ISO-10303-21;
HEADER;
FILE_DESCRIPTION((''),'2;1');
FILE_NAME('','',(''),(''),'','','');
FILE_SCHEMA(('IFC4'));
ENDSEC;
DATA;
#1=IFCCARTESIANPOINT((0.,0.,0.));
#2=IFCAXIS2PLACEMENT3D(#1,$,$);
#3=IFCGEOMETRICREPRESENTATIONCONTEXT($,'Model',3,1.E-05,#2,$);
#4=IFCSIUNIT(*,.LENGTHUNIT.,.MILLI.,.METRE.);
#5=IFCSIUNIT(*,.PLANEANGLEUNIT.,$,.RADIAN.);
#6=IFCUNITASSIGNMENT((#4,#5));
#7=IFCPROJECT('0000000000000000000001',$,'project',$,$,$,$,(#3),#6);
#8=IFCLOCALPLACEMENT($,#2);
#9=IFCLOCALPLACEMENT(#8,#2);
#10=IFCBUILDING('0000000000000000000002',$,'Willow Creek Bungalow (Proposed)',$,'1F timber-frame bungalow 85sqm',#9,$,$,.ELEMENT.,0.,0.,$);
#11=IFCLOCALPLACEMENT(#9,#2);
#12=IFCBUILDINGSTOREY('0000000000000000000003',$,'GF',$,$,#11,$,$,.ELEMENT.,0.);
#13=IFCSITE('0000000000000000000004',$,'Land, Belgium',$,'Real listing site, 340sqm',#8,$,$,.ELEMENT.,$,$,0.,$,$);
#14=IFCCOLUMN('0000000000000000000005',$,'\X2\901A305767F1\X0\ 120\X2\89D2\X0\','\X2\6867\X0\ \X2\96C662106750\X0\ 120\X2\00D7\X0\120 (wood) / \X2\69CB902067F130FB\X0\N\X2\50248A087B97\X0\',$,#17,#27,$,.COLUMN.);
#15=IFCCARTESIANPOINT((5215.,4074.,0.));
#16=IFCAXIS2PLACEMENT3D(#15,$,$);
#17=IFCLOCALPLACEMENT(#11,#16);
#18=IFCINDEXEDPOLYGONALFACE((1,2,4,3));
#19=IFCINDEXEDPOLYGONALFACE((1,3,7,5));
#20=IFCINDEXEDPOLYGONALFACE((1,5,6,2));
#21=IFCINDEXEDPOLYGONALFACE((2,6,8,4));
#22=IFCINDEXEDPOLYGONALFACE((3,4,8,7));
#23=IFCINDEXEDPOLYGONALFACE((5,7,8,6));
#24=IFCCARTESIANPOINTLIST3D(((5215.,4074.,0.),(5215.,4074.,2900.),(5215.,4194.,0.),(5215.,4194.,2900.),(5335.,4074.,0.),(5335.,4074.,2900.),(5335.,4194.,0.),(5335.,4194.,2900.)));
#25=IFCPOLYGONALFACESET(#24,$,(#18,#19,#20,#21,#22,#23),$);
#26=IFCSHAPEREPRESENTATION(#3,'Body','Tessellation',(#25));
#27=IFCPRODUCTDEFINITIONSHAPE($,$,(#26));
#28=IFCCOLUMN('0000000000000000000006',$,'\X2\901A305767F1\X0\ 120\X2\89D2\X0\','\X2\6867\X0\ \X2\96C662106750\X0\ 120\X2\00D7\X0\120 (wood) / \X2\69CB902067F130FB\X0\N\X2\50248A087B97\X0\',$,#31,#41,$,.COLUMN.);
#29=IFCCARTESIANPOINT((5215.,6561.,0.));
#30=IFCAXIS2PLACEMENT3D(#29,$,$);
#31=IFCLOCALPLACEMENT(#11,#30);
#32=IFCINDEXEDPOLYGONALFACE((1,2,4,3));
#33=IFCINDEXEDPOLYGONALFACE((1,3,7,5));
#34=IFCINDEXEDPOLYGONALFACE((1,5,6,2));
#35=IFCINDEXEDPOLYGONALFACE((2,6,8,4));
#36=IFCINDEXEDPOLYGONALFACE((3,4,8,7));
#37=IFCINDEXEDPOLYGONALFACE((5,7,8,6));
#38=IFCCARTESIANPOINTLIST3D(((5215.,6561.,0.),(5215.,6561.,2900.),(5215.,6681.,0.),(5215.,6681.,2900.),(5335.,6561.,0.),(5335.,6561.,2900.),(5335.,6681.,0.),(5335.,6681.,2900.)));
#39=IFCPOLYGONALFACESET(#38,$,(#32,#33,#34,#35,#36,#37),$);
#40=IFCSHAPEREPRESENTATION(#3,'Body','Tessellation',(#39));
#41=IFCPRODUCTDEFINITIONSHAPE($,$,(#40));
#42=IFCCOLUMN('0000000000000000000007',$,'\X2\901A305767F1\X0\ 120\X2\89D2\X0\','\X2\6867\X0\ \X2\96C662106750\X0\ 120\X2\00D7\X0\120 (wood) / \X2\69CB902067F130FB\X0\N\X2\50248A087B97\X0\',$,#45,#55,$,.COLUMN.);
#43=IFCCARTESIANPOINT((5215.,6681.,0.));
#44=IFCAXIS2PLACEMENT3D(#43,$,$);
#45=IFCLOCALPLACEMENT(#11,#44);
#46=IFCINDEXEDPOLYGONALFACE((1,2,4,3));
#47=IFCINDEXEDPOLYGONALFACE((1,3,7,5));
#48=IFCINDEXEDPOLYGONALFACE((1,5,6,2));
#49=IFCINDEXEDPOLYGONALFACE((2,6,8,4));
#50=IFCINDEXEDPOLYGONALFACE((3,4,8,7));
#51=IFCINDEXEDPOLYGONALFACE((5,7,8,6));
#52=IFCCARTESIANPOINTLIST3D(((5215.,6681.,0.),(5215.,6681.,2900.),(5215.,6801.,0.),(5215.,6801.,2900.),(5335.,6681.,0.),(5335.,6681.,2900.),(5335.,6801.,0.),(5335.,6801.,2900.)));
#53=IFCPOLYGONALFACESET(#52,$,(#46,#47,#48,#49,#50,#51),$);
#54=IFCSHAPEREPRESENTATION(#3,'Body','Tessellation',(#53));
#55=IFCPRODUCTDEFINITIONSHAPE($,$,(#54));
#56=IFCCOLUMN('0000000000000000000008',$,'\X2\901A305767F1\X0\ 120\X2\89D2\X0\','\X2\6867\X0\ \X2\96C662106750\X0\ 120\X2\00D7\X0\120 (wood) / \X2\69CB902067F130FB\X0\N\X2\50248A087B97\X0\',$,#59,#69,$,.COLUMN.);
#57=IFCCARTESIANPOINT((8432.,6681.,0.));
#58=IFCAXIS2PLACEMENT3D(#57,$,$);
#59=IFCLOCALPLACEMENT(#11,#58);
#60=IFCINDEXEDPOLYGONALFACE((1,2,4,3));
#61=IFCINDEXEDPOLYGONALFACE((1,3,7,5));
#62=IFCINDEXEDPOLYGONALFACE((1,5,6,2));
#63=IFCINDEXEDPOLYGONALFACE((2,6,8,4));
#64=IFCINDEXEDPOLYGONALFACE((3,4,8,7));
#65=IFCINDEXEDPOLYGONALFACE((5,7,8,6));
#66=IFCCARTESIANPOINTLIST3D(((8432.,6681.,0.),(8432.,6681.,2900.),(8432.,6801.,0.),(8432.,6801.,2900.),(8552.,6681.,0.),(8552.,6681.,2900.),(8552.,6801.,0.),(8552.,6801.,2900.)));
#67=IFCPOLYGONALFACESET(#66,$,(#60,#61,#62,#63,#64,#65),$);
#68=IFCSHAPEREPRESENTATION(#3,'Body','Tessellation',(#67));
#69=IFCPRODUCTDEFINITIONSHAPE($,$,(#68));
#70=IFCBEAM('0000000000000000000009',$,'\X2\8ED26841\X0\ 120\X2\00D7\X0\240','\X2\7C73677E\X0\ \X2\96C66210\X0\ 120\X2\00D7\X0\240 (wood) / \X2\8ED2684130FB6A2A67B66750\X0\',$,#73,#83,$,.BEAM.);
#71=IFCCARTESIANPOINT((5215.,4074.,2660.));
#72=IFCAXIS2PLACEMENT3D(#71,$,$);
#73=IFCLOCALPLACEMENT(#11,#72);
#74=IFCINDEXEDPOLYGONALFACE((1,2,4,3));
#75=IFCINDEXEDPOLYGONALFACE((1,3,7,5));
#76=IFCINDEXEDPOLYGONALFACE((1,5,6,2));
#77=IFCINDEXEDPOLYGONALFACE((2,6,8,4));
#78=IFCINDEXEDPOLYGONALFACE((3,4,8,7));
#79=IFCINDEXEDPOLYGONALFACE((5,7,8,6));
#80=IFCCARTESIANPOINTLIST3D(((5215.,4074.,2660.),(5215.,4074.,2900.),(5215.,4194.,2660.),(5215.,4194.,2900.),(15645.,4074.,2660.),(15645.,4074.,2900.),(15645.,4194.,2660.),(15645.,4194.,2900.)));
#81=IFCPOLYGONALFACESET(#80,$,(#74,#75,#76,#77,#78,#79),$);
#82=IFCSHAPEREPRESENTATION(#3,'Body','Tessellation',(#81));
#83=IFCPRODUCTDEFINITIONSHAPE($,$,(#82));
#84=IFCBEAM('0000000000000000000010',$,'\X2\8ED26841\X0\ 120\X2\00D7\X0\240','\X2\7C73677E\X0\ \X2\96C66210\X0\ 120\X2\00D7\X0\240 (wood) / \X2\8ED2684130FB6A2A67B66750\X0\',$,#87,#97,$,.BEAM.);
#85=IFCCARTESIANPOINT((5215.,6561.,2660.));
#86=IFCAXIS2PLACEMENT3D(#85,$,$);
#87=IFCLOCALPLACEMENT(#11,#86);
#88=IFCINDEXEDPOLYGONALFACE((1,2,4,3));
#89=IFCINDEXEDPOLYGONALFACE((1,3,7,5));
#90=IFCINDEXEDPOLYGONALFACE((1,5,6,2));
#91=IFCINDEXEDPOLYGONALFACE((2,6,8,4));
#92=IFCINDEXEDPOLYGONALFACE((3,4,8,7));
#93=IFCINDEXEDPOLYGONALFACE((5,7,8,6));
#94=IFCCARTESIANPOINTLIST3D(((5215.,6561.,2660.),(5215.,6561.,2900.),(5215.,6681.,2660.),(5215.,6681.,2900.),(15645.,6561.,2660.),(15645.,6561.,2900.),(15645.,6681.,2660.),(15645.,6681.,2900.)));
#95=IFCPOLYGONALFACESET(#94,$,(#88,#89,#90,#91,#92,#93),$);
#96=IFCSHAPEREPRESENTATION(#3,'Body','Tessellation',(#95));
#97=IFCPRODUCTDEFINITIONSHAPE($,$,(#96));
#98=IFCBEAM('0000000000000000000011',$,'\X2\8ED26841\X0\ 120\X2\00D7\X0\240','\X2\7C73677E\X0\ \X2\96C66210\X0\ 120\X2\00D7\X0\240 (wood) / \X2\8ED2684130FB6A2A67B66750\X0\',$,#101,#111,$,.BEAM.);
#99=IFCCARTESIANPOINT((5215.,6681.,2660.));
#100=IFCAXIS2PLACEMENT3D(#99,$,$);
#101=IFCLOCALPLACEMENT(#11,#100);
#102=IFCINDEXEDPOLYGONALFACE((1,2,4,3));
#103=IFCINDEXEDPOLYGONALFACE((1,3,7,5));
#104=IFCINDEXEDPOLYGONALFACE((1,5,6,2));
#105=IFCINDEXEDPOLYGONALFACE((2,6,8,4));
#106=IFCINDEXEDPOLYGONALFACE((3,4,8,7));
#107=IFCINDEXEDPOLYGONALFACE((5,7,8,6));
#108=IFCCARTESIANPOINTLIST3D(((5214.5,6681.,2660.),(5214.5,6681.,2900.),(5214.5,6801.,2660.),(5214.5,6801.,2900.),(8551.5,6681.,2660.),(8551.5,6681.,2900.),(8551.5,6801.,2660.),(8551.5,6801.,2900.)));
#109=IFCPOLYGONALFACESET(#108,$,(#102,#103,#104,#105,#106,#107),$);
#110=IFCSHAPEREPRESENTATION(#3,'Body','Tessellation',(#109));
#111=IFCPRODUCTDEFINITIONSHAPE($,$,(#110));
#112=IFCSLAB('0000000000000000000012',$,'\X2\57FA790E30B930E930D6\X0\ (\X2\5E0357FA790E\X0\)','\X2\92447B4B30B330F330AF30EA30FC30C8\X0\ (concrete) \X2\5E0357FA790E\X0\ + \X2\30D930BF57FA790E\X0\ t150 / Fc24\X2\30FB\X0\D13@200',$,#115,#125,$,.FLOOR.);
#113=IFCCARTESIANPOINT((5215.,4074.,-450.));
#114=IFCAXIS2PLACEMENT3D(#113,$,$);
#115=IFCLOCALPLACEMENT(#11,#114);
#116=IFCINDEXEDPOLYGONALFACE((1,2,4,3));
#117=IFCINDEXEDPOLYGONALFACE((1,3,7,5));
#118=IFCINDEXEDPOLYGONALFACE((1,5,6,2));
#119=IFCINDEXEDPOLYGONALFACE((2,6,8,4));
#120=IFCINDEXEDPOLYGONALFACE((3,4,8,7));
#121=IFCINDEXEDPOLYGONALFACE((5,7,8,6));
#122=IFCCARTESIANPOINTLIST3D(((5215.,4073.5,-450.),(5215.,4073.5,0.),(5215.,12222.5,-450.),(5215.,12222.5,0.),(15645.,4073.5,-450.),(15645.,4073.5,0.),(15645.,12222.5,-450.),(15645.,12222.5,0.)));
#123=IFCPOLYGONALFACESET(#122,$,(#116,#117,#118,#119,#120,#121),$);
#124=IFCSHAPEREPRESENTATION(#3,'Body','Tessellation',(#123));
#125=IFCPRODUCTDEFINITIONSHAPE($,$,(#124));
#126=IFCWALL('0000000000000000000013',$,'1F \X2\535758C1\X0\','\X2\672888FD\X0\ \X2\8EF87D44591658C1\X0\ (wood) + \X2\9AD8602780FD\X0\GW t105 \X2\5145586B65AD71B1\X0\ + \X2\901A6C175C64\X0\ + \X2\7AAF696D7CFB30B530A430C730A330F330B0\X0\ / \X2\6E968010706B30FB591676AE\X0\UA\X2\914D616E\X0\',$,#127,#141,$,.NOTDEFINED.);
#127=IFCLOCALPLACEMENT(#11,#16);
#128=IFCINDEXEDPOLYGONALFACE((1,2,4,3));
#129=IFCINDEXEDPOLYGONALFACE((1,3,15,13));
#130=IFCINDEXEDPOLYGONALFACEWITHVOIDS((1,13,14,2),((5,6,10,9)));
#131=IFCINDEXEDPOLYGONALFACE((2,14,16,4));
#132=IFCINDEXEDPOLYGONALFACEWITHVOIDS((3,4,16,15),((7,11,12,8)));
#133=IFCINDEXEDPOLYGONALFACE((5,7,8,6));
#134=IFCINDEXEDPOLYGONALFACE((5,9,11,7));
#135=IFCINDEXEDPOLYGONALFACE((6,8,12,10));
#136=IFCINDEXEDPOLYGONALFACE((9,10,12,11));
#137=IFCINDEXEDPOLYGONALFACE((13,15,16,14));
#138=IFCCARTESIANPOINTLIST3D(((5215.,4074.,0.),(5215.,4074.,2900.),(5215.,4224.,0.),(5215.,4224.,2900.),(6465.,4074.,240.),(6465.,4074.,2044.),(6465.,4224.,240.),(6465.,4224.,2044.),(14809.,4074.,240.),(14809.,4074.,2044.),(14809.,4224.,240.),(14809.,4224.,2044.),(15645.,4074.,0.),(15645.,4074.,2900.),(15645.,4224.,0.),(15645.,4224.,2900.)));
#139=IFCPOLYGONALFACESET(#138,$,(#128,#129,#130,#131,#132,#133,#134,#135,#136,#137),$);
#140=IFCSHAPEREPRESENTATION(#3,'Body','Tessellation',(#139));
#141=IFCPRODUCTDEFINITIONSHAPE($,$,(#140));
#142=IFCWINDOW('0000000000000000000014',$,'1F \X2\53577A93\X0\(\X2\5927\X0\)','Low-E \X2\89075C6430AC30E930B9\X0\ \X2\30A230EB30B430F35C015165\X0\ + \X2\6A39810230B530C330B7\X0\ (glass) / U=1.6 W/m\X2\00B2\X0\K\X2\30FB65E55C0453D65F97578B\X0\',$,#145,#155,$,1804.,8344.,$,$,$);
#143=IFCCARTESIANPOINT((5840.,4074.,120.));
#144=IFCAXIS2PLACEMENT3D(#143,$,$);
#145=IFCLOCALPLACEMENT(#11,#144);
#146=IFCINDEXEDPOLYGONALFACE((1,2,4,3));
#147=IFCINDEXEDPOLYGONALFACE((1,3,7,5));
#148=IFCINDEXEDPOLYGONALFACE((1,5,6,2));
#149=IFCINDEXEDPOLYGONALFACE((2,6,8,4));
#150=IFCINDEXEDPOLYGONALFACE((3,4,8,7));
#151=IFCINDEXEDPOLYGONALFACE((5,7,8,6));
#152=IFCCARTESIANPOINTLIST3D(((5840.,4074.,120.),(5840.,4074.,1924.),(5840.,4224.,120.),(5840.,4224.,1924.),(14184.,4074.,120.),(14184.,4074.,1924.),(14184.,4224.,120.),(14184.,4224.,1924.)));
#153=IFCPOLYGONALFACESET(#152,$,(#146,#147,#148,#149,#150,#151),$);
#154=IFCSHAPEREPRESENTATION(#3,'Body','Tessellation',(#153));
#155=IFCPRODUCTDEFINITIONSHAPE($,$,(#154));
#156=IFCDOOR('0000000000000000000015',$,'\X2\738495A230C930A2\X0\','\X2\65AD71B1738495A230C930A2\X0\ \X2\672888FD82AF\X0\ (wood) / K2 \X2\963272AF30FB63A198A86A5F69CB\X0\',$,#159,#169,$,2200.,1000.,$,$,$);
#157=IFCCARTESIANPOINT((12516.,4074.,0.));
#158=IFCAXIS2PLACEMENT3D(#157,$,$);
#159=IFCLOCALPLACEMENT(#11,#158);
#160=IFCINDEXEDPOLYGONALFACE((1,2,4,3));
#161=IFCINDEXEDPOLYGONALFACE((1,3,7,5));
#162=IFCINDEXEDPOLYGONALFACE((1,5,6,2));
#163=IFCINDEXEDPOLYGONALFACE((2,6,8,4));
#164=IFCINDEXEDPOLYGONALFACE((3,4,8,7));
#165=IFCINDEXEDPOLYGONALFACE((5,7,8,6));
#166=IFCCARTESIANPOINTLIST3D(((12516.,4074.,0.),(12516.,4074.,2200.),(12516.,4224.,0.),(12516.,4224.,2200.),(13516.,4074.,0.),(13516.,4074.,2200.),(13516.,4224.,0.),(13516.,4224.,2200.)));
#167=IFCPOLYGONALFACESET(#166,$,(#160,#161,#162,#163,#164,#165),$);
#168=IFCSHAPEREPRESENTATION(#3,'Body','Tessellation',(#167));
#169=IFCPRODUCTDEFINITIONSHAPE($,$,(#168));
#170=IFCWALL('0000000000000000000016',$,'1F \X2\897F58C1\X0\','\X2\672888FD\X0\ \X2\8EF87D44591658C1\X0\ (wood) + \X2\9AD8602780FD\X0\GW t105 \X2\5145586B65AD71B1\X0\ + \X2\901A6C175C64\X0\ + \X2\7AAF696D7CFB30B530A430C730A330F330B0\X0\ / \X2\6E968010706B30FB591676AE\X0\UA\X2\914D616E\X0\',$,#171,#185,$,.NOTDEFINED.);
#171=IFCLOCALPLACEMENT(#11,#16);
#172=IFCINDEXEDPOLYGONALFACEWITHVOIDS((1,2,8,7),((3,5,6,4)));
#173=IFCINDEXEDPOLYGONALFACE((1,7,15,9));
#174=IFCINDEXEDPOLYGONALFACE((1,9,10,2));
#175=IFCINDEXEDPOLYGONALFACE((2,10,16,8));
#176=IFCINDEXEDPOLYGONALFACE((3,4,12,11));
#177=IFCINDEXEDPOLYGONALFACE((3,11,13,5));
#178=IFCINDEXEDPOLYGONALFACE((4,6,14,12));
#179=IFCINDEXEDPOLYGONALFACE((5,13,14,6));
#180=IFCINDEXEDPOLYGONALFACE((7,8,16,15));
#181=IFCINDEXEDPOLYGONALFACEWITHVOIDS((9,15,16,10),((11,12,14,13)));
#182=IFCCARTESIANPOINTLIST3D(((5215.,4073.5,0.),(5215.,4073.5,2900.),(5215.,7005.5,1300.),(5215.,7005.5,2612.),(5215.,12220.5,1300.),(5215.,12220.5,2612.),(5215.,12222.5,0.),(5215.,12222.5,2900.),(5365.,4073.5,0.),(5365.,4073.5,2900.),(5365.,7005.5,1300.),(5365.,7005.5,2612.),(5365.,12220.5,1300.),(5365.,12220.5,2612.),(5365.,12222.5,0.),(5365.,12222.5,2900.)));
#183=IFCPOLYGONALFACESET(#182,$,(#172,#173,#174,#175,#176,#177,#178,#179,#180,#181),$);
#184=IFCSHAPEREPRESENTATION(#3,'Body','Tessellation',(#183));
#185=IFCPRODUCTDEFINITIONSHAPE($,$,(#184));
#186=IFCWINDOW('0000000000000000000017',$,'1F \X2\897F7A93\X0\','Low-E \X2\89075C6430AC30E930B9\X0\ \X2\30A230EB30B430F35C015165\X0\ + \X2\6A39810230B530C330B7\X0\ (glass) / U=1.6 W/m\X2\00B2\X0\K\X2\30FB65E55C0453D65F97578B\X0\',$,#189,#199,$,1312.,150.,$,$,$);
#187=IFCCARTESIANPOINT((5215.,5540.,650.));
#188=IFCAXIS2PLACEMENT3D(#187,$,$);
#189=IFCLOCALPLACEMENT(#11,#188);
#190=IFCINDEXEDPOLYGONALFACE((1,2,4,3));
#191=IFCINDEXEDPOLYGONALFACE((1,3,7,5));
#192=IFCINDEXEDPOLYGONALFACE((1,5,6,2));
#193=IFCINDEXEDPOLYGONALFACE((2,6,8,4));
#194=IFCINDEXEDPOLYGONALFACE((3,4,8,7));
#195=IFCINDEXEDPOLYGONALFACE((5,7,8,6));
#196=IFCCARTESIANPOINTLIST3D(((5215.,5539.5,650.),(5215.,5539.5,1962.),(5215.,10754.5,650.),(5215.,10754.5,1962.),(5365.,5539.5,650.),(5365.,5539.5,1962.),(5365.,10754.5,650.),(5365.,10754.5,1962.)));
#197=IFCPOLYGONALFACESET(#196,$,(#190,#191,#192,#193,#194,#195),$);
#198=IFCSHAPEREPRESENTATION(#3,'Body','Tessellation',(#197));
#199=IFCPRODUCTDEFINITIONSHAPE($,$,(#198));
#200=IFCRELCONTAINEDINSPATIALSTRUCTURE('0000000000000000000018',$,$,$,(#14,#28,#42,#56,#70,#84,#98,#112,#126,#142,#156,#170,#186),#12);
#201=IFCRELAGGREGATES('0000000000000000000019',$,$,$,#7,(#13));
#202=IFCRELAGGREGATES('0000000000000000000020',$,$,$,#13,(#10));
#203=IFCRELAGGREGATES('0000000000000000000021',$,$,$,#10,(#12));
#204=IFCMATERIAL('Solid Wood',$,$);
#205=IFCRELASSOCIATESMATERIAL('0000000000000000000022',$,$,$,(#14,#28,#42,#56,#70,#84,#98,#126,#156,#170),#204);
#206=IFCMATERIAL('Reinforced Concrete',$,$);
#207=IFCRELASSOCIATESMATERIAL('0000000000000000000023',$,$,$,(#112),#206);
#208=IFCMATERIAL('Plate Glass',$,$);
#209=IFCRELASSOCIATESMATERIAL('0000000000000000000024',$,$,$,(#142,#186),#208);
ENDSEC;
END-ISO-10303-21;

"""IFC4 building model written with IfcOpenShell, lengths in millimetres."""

from ifc_helpers import new_model, si_unit, frame, frame_2d, origin, place, context, project, spatial, rectangle, extrude, material, element, fill, save


model = new_model("IFC4")

# Units and contexts
model_context = context("Model", 3, precision=1e-05, world=origin())
ifc_project = project(units=[si_unit("LENGTHUNIT", "METRE", prefix="MILLI"), si_unit("PLANEANGLEUNIT", "RADIAN")], contexts=[model_context])

# Site, building, storey
site_placement = place(None, origin())
site = spatial("IfcSite", under=ifc_project, at=site_placement, Name="Land, Belgium", ObjectType="Real listing site, 340sqm", CompositionType="ELEMENT", RefElevation=0.0)
building_placement = place(site_placement, origin())
building = spatial("IfcBuilding", under=site, at=building_placement, Name="Willow Creek Bungalow (Proposed)", ObjectType="1F timber-frame bungalow 85sqm", CompositionType="ELEMENT", ElevationOfRefHeight=0.0, ElevationOfTerrain=0.0)
storey_placement = place(building_placement, origin())
storey = spatial("IfcBuildingStorey", under=building, at=storey_placement, Name="GF", CompositionType="ELEMENT", Elevation=0.0)

# Columns
ifc_material_1 = material(Name="Solid Wood")
column_1_placement = place(storey_placement, frame((5215.0, 4074.0, 0.0)))
element("IfcColumn", 1, at=column_1_placement, inside=storey, material=ifc_material_1, Name="通し柱 120角", Description="桧 集成材 120×120 (wood) / 構造柱・N値計算", PredefinedType="COLUMN", context=model_context, shape_type="SweptSolid", body=[
    extrude(rectangle(XDim=120.0, YDim=120.0, at=frame_2d((60.0, 60.0))), frame((5215.0, 4074.0, 0.0)), (0.0, 0.0, 1.0), 2900.0),
])
column_2_placement = place(storey_placement, frame((5215.0, 6561.0, 0.0)))
element("IfcColumn", 2, at=column_2_placement, inside=storey, material=ifc_material_1, Name="通し柱 120角", Description="桧 集成材 120×120 (wood) / 構造柱・N値計算", PredefinedType="COLUMN", context=model_context, shape_type="SweptSolid", body=[
    extrude(rectangle(XDim=120.0, YDim=120.0, at=frame_2d((60.0, 60.0))), frame((5215.0, 6561.0, 0.0)), (0.0, 0.0, 1.0), 2900.0),
])
column_3_placement = place(storey_placement, frame((5215.0, 6681.0, 0.0)))
element("IfcColumn", 3, at=column_3_placement, inside=storey, material=ifc_material_1, Name="通し柱 120角", Description="桧 集成材 120×120 (wood) / 構造柱・N値計算", PredefinedType="COLUMN", context=model_context, shape_type="SweptSolid", body=[
    extrude(rectangle(XDim=120.0, YDim=120.0, at=frame_2d((60.0, 60.0))), frame((5215.0, 6681.0, 0.0)), (0.0, 0.0, 1.0), 2900.0),
])
column_4_placement = place(storey_placement, frame((8432.0, 6681.0, 0.0)))
element("IfcColumn", 4, at=column_4_placement, inside=storey, material=ifc_material_1, Name="通し柱 120角", Description="桧 集成材 120×120 (wood) / 構造柱・N値計算", PredefinedType="COLUMN", context=model_context, shape_type="SweptSolid", body=[
    extrude(rectangle(XDim=120.0, YDim=120.0, at=frame_2d((60.0, 60.0))), frame((8432.0, 6681.0, 0.0)), (0.0, 0.0, 1.0), 2900.0),
])

# Beams
beam_1_placement = place(storey_placement, frame((5215.0, 4074.0, 2660.0)))
element("IfcBeam", 5, at=beam_1_placement, inside=storey, material=ifc_material_1, Name="軒桁 120×240", Description="米松 集成 120×240 (wood) / 軒桁・横架材", PredefinedType="BEAM", context=model_context, shape_type="SweptSolid", body=[
    extrude(rectangle(XDim=10430.0, YDim=120.0, at=frame_2d((5215.0, 60.0))), frame((5215.0, 4074.0, 2660.0)), (0.0, 0.0, 1.0), 240.0),
])
beam_2_placement = place(storey_placement, frame((5215.0, 6561.0, 2660.0)))
element("IfcBeam", 6, at=beam_2_placement, inside=storey, material=ifc_material_1, Name="軒桁 120×240", Description="米松 集成 120×240 (wood) / 軒桁・横架材", PredefinedType="BEAM", context=model_context, shape_type="SweptSolid", body=[
    extrude(rectangle(XDim=10430.0, YDim=120.0, at=frame_2d((5215.0, 60.0))), frame((5215.0, 6561.0, 2660.0)), (0.0, 0.0, 1.0), 240.0),
])
beam_3_placement = place(storey_placement, frame((5215.0, 6681.0, 2660.0)))
element("IfcBeam", 7, at=beam_3_placement, inside=storey, material=ifc_material_1, Name="軒桁 120×240", Description="米松 集成 120×240 (wood) / 軒桁・横架材", PredefinedType="BEAM", context=model_context, shape_type="SweptSolid", body=[
    extrude(rectangle(XDim=3337.0, YDim=120.0, at=frame_2d((1668.0, 60.0))), frame((5215.0, 6681.0, 2660.0)), (0.0, 0.0, 1.0), 240.0),
])

# Slab
ifc_material_2 = material(Name="Reinforced Concrete")
slab_1_placement = place(storey_placement, frame((5215.0, 4074.0, -450.0)))
element("IfcSlab", 8, at=slab_1_placement, inside=storey, material=ifc_material_2, Name="基礎スラブ (布基礎)", Description="鉄筋コンクリート (concrete) 布基礎 + ベタ基礎 t150 / Fc24・D13@200", PredefinedType="FLOOR", context=model_context, shape_type="SweptSolid", body=[
    extrude(rectangle(XDim=10430.0, YDim=8149.0, at=frame_2d((5215.0, 4074.0))), frame((5215.0, 4074.0, -450.0)), (0.0, 0.0, 1.0), 450.0),
])

# Wall, openings, window, door
wall_1_placement = place(storey_placement, frame((5215.0, 4074.0, 0.0)))
wall_1 = element("IfcWall", 9, at=wall_1_placement, inside=storey, material=ifc_material_1, Name="1F 南壁", Description="木製 軸組外壁 (wood) + 高性能GW t105 充填断熱 + 通気層 + 窯業系サイディング / 準耐火・外皮UA配慮", PredefinedType="NOTDEFINED", context=model_context, shape_type="SweptSolid", body=[
    extrude(rectangle(XDim=10430.0, YDim=150.0, at=frame_2d((5215.0, 75.0))), frame((5215.0, 4074.0, 0.0)), (0.0, 0.0, 1.0), 2900.0),
])
opening_1_placement = place(storey_placement, frame((5840.0, 4074.0, 120.0)))
opening_1 = element("IfcOpeningElement", 10, at=opening_1_placement, cuts=wall_1, PredefinedType="NOTDEFINED", context=model_context, shape_type="SweptSolid", body=[
    extrude(rectangle(XDim=8344.0, YDim=150.0, at=frame_2d((4172.0, 75.0))), frame((5840.0, 4074.0, 120.0)), (0.0, 0.0, 1.0), 1804.0),
])
opening_2_placement = place(storey_placement, frame((12516.0, 4074.0, 0.0)))
opening_2 = element("IfcOpeningElement", 11, at=opening_2_placement, cuts=wall_1, PredefinedType="NOTDEFINED", context=model_context, shape_type="SweptSolid", body=[
    extrude(rectangle(XDim=1000.0, YDim=150.0, at=frame_2d((500.0, 75.0))), frame((12516.0, 4074.0, 0.0)), (0.0, 0.0, 1.0), 2200.0),
])
ifc_material_3 = material(Name="Plate Glass")
window_1_placement = place(storey_placement, frame((5840.0, 4074.0, 120.0)))
window_1 = element("IfcWindow", 12, at=window_1_placement, inside=storey, material=ifc_material_3, Name="1F 南窓(大)", Description="Low-E 複層ガラス アルゴン封入 + 樹脂サッシ (glass) / U=1.6 W/m²K・日射取得型", OverallHeight=1804.0, OverallWidth=8344.0, context=model_context, shape_type="SweptSolid", body=[
    extrude(rectangle(XDim=8344.0, YDim=150.0, at=frame_2d((4172.0, 75.0))), frame((5840.0, 4074.0, 120.0)), (0.0, 0.0, 1.0), 1804.0),
])
fill(opening_1, window_1)
door_placement = place(storey_placement, frame((12516.0, 4074.0, 0.0)))
door = element("IfcDoor", 13, at=door_placement, inside=storey, material=ifc_material_1, Name="玄関ドア", Description="断熱玄関ドア 木製芯 (wood) / K2 防犯・採風機構", OverallHeight=2200.0, OverallWidth=1000.0, context=model_context, shape_type="SweptSolid", body=[
    extrude(rectangle(XDim=1000.0, YDim=150.0, at=frame_2d((500.0, 75.0))), frame((12516.0, 4074.0, 0.0)), (0.0, 0.0, 1.0), 2200.0),
])
fill(opening_2, door)

# Wall, opening, window
wall_2_placement = place(storey_placement, frame((5215.0, 4074.0, 0.0)))
wall_2 = element("IfcWall", 14, at=wall_2_placement, inside=storey, material=ifc_material_1, Name="1F 西壁", Description="木製 軸組外壁 (wood) + 高性能GW t105 充填断熱 + 通気層 + 窯業系サイディング / 準耐火・外皮UA配慮", PredefinedType="NOTDEFINED", context=model_context, shape_type="SweptSolid", body=[
    extrude(rectangle(XDim=150.0, YDim=8149.0, at=frame_2d((75.0, 4074.0))), frame((5215.0, 4074.0, 0.0)), (0.0, 0.0, 1.0), 2900.0),
])
opening_3_placement = place(storey_placement, frame((5215.0, 5540.0, 650.0)))
opening_3 = element("IfcOpeningElement", 15, at=opening_3_placement, cuts=wall_2, PredefinedType="NOTDEFINED", context=model_context, shape_type="SweptSolid", body=[
    extrude(rectangle(XDim=150.0, YDim=5215.0, at=frame_2d((75.0, 2607.0))), frame((5215.0, 5540.0, 650.0)), (0.0, 0.0, 1.0), 1312.0),
])
window_2_placement = place(storey_placement, frame((5215.0, 5540.0, 650.0)))
window_2 = element("IfcWindow", 16, at=window_2_placement, inside=storey, material=ifc_material_3, Name="1F 西窓", Description="Low-E 複層ガラス アルゴン封入 + 樹脂サッシ (glass) / U=1.6 W/m²K・日射取得型", OverallHeight=1312.0, OverallWidth=150.0, context=model_context, shape_type="SweptSolid", body=[
    extrude(rectangle(XDim=150.0, YDim=5215.0, at=frame_2d((75.0, 2607.0))), frame((5215.0, 5540.0, 650.0)), (0.0, 0.0, 1.0), 1312.0),
])
fill(opening_3, window_2)

save(model, "model.ifc")
